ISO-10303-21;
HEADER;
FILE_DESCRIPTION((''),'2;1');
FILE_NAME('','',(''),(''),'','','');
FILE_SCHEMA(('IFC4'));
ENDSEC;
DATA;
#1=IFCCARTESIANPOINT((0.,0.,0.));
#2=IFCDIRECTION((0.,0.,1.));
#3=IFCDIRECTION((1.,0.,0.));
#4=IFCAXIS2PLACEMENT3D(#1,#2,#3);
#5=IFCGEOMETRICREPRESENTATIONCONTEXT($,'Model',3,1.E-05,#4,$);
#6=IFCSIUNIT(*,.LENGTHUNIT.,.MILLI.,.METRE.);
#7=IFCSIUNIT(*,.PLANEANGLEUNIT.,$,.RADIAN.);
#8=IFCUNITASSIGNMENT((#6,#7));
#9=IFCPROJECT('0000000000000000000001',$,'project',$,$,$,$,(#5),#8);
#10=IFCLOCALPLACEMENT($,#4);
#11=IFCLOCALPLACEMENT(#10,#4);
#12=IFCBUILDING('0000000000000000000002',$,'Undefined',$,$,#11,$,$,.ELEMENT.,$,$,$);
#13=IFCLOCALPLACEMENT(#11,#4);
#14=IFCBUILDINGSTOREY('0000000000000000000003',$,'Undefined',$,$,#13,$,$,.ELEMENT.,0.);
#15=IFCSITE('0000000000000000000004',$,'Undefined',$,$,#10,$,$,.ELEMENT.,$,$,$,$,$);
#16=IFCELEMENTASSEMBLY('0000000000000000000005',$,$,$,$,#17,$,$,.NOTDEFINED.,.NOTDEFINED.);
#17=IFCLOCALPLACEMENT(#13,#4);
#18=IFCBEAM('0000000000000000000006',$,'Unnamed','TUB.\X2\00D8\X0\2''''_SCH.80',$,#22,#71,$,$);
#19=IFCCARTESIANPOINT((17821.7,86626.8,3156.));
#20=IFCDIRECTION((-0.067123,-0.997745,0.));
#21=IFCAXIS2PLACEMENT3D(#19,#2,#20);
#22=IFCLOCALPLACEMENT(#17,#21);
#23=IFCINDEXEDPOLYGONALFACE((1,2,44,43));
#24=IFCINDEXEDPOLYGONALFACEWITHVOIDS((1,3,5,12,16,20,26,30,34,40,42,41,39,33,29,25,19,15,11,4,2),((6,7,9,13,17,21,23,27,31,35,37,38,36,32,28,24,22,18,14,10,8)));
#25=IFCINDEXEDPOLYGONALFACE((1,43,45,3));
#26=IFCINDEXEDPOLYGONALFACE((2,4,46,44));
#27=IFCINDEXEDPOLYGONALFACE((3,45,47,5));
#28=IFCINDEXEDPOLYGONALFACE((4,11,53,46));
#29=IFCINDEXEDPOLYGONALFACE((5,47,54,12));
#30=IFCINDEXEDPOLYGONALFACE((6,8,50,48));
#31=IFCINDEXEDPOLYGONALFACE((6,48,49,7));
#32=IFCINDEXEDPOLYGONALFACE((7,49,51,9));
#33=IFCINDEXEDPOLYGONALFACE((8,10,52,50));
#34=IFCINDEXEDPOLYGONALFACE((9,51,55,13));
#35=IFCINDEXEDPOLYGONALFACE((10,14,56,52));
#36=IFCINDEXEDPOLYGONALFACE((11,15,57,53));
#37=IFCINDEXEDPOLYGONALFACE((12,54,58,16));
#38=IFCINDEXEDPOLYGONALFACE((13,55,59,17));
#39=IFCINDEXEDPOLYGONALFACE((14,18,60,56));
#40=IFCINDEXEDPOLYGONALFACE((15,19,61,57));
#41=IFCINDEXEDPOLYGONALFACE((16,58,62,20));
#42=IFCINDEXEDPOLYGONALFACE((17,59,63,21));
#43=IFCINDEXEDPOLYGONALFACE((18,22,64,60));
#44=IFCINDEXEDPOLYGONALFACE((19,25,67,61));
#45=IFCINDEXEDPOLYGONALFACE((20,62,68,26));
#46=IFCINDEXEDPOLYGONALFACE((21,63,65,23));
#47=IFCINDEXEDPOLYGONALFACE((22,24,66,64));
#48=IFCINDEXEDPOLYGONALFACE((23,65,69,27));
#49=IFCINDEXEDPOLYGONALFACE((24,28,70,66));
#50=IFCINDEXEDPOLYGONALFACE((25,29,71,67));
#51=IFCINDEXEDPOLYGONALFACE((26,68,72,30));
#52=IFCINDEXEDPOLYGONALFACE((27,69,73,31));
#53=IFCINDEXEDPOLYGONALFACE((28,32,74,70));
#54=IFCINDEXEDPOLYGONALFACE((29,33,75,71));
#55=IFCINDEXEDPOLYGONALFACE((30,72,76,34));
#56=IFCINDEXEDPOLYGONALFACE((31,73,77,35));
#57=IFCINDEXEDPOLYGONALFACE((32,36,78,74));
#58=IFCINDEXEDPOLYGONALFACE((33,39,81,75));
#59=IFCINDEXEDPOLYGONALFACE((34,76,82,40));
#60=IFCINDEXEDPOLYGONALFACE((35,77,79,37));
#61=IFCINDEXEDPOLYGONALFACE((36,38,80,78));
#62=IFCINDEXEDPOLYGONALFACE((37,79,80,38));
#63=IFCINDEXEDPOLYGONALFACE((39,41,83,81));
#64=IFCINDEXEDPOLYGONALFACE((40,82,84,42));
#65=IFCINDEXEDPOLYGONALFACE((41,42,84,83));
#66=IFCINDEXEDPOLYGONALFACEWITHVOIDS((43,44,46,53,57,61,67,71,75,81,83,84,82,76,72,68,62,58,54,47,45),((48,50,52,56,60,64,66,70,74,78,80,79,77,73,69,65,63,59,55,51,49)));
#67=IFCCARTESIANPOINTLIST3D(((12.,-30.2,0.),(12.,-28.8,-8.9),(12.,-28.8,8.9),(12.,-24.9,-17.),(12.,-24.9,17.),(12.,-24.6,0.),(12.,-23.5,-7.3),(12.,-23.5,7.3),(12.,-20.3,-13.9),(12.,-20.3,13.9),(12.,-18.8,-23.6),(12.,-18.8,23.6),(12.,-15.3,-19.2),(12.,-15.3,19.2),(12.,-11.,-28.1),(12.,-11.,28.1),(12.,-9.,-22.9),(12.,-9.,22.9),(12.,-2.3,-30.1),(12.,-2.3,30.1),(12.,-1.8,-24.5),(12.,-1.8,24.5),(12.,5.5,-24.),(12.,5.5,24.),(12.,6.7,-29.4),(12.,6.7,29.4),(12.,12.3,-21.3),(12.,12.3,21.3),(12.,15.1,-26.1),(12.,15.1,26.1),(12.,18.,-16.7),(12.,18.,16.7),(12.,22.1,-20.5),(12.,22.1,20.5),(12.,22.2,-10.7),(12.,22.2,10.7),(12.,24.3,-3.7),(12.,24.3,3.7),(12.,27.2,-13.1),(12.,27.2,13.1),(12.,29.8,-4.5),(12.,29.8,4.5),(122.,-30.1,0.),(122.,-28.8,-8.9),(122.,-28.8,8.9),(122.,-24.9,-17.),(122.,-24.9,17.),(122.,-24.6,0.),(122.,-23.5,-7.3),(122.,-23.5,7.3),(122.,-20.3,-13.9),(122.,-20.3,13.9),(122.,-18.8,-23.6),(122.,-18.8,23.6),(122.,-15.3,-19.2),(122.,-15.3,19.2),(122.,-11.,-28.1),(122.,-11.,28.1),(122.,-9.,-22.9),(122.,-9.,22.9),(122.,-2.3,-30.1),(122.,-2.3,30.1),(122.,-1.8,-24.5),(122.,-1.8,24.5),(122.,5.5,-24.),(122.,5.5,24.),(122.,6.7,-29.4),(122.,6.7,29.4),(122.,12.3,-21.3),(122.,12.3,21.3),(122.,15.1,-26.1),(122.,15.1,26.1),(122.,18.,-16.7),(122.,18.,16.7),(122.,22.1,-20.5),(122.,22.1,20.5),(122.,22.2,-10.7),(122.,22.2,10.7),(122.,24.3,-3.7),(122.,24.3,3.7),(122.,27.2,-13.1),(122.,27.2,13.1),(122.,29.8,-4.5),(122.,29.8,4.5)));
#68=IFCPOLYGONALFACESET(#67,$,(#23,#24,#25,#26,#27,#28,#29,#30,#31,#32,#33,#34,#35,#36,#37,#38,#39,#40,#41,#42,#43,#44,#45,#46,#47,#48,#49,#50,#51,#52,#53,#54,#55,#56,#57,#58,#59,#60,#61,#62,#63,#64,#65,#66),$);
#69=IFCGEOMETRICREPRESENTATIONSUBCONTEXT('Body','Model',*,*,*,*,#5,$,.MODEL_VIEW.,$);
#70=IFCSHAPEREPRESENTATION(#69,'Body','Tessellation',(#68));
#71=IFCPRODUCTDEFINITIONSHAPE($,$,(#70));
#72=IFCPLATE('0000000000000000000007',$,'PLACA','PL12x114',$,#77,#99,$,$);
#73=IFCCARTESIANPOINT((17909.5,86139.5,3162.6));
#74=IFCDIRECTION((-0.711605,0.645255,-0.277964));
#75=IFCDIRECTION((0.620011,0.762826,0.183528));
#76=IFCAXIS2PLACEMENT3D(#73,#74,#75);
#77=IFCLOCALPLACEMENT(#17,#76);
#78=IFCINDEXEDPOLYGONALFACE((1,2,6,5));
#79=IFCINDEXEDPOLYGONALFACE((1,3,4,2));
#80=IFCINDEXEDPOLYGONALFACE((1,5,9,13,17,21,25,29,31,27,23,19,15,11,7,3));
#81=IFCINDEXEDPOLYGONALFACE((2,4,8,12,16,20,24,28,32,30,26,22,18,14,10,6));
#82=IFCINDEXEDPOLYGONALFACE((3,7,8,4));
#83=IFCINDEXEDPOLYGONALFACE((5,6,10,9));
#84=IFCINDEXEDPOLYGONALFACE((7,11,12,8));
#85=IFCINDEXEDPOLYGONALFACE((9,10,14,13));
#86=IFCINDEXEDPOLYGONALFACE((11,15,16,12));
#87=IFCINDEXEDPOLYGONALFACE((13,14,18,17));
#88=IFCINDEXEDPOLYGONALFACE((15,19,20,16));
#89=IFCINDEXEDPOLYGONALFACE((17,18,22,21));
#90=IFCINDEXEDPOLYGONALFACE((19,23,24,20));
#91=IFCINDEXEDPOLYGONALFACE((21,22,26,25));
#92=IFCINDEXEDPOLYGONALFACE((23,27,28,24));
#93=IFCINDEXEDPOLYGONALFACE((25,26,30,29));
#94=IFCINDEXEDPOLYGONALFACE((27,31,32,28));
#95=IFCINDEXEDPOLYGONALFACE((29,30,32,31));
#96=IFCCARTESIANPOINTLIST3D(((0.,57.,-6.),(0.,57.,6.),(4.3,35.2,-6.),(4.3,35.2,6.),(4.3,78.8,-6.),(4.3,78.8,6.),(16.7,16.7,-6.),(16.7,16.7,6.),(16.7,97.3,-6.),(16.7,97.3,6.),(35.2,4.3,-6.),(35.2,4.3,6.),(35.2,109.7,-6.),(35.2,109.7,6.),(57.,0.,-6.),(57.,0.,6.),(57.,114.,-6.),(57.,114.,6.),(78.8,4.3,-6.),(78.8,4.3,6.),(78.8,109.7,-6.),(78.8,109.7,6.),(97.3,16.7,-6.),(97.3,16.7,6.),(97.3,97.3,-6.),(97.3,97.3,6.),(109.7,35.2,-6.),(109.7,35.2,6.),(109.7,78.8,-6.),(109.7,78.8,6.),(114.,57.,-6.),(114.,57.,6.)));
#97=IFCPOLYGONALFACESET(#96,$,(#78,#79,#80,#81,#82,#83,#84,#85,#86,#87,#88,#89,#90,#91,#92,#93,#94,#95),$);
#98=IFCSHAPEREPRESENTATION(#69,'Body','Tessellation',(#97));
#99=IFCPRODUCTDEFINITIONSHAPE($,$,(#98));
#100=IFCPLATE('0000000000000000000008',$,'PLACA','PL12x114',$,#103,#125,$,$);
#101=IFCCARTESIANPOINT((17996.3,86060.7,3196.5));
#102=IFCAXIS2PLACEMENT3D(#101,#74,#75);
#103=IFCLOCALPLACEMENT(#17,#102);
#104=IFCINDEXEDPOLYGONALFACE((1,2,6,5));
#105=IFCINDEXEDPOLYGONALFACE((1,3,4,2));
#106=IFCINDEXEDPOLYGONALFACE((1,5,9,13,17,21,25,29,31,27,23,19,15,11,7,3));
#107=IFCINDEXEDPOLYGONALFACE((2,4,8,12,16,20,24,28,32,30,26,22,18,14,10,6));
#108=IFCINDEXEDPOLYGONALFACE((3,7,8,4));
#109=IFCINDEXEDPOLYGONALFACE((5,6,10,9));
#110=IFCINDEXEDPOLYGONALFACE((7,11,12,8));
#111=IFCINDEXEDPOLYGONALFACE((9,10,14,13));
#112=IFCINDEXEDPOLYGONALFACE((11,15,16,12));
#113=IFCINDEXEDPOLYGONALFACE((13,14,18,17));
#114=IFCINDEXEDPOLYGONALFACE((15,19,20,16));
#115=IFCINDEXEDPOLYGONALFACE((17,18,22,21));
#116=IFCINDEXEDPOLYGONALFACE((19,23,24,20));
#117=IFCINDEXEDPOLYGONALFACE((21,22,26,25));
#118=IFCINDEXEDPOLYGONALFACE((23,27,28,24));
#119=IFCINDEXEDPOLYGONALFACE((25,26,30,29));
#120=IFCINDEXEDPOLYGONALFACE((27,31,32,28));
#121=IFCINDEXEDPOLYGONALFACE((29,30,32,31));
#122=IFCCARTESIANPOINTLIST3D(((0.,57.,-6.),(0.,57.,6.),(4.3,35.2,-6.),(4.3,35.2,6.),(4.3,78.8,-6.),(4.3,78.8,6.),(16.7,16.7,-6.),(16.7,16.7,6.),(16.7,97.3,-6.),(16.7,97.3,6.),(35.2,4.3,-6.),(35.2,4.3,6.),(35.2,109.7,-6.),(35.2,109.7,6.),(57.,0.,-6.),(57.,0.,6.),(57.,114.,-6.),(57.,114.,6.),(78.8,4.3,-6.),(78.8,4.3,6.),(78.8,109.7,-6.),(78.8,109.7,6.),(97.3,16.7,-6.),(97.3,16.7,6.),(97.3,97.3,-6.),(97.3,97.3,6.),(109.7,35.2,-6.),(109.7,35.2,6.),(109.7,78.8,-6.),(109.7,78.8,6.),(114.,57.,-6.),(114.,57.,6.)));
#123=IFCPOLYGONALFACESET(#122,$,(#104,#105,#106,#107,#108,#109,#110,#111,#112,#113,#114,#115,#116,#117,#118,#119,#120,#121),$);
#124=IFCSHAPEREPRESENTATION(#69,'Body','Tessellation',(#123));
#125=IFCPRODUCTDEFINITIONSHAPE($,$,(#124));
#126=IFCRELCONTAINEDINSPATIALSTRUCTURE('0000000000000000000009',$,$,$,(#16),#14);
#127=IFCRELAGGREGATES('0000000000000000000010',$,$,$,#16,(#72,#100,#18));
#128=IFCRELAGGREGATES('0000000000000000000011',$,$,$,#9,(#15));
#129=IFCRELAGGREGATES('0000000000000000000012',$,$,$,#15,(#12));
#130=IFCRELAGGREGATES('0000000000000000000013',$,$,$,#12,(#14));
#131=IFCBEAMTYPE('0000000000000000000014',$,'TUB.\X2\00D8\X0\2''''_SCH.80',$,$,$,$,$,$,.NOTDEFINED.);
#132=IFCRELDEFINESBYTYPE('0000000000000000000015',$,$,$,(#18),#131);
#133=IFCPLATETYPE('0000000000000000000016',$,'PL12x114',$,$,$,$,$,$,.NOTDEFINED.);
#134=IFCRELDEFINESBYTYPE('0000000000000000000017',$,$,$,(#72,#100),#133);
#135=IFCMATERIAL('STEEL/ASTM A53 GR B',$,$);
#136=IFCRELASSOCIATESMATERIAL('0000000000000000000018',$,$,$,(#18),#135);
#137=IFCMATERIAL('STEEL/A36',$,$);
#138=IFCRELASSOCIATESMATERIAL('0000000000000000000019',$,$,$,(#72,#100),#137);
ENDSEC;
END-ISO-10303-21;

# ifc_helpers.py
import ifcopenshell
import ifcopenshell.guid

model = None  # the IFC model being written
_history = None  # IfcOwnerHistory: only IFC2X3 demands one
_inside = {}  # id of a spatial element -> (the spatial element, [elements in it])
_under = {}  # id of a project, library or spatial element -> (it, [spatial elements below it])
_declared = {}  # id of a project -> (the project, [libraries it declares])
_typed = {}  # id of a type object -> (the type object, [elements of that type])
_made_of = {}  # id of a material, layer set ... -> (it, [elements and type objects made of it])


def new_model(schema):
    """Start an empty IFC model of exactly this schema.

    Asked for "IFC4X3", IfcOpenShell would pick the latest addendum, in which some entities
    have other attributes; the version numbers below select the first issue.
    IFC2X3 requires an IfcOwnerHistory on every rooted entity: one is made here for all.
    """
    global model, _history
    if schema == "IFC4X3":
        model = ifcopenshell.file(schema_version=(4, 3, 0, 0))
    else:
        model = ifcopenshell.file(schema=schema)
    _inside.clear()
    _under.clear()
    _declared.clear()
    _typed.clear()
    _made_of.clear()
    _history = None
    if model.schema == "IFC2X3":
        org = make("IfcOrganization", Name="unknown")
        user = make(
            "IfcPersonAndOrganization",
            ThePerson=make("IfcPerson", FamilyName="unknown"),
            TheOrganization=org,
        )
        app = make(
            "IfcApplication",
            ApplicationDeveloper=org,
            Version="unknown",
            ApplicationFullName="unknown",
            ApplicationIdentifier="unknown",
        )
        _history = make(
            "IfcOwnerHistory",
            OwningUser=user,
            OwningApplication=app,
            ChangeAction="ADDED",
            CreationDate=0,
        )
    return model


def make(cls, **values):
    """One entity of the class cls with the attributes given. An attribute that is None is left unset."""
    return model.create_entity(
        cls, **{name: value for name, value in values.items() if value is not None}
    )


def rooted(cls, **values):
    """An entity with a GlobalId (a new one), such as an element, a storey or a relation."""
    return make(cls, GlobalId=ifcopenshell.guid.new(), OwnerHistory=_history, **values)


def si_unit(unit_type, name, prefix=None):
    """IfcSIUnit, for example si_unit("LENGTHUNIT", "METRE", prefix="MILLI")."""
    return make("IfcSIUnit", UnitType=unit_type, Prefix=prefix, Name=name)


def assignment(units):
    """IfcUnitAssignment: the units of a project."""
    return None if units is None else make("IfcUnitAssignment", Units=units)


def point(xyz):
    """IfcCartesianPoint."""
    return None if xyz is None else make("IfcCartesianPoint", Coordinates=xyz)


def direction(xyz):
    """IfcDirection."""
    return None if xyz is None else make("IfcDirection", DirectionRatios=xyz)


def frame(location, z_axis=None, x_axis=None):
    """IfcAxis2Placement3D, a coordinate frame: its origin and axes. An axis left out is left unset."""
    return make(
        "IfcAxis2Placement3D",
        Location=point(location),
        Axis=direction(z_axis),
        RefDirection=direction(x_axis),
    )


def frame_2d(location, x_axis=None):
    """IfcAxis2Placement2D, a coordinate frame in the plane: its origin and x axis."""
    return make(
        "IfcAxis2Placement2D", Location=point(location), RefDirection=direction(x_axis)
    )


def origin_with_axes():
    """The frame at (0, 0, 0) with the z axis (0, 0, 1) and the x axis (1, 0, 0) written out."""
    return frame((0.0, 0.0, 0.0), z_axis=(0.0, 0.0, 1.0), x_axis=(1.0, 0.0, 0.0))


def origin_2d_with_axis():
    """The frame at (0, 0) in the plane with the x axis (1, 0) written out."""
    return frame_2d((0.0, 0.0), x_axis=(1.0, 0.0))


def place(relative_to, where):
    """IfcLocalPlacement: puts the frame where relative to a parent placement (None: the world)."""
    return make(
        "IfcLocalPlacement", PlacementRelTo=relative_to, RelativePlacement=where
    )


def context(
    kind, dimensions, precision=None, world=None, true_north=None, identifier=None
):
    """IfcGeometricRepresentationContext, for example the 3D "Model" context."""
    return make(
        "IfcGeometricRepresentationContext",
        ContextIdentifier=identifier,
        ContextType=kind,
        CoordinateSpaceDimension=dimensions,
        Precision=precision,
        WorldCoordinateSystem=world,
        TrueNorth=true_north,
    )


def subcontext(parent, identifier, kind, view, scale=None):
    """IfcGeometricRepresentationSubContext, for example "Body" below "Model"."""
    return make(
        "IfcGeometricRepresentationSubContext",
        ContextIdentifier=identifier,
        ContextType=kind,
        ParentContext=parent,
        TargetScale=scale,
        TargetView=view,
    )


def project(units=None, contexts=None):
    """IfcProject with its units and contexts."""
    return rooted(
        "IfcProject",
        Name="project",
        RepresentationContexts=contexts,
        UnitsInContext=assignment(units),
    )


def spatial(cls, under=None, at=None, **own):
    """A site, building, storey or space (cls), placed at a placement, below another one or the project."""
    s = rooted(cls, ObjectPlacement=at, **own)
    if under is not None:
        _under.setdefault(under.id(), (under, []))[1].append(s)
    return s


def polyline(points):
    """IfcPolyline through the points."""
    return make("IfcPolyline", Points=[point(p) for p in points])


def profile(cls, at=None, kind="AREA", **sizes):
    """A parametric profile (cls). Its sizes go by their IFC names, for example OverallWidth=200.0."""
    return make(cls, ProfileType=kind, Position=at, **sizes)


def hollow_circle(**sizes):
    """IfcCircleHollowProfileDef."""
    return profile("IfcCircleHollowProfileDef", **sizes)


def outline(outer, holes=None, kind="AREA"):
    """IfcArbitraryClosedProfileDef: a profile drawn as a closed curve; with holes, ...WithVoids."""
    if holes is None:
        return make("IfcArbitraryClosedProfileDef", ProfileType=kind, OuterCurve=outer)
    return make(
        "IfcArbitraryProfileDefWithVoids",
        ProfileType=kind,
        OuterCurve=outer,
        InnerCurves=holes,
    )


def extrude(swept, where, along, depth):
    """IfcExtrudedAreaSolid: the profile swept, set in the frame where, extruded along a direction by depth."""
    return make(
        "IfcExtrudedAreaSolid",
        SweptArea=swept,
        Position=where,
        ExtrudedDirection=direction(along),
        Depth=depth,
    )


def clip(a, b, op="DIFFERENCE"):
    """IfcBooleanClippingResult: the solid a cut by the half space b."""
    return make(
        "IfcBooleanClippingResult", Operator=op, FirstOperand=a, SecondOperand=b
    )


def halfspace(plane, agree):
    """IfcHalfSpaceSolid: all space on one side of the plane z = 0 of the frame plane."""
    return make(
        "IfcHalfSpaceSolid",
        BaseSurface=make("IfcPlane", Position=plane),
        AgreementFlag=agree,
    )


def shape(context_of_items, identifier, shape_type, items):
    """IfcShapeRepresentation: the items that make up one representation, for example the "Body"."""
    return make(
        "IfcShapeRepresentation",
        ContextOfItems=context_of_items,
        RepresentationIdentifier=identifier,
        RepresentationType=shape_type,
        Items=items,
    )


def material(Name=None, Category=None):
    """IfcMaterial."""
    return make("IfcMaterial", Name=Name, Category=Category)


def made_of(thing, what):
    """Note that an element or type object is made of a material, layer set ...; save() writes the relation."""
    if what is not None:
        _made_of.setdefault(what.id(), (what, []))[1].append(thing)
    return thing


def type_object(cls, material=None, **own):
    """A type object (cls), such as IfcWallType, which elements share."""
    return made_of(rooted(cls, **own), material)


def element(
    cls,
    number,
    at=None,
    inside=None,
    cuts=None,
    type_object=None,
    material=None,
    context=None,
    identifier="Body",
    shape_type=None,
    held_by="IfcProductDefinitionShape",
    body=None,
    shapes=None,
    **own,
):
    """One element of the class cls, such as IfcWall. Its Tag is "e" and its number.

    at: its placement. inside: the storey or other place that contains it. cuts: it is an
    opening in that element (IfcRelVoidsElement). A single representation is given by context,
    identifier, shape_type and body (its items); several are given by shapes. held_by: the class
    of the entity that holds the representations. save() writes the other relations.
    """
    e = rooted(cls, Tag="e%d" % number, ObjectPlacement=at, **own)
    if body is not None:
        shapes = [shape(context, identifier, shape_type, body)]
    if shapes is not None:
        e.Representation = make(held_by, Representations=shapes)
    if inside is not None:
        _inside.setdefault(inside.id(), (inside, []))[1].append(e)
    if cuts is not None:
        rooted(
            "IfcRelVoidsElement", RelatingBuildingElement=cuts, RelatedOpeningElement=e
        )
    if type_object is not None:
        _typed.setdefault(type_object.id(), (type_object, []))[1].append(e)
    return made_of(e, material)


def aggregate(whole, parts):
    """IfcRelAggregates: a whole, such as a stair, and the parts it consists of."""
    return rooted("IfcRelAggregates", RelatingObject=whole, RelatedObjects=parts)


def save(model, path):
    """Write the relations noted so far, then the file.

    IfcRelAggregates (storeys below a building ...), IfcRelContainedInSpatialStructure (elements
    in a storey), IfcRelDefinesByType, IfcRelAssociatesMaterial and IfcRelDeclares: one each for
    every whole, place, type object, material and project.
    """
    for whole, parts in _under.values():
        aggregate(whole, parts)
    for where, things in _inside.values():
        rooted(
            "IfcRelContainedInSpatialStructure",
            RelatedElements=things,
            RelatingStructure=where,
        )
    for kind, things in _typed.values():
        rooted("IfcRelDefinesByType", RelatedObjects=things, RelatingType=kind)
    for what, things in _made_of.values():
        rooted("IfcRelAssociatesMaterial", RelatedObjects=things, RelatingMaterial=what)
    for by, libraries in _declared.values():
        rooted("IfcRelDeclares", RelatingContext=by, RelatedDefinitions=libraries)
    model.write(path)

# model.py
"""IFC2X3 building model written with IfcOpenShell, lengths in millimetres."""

from ifc_helpers import new_model, si_unit, frame, origin_with_axes, origin_2d_with_axis, place, context, subcontext, project, spatial, polyline, hollow_circle, outline, extrude, clip, halfspace, material, type_object, element, aggregate, save


model = new_model("IFC2X3")

# Units and contexts
model_context = context("Model", 3, precision=1e-05, world=origin_with_axes())
body_context = subcontext(model_context, "Body", "Model", "MODEL_VIEW")
ifc_project = project(units=[si_unit("LENGTHUNIT", "METRE", prefix="MILLI"), si_unit("PLANEANGLEUNIT", "RADIAN")], contexts=[model_context])

# Site, building, storey
site_placement = place(None, origin_with_axes())
site = spatial("IfcSite", under=ifc_project, at=site_placement, Name="Undefined", CompositionType="ELEMENT")
building_placement = place(site_placement, origin_with_axes())
building = spatial("IfcBuilding", under=site, at=building_placement, Name="Undefined", CompositionType="ELEMENT")
storey_placement = place(building_placement, origin_with_axes())
storey = spatial("IfcBuildingStorey", under=building, at=storey_placement, Name="Undefined", CompositionType="ELEMENT", Elevation=0.0)

# Element assembly, beam, plates
assembly_placement = place(storey_placement, origin_with_axes())
assembly = element("IfcElementAssembly", 1, at=assembly_placement, inside=storey, AssemblyPlace="NOTDEFINED", PredefinedType="NOTDEFINED")
ifc_material_1 = material(Name="STEEL/ASTM A53 GR B")
beam_type_1 = type_object("IfcBeamType", Name="TUB.Ø2''_SCH.80", PredefinedType="NOTDEFINED")
beam_1_placement = place(assembly_placement, frame((17821.7, 86626.8, 3156.0), z_axis=(0.0, 0.0, 1.0), x_axis=(-0.067123, -0.997745, 0.0)))
beam_1 = element("IfcBeam", 2, at=beam_1_placement, type_object=beam_type_1, material=ifc_material_1, Name="Unnamed", Description="TUB.Ø2''_SCH.80", context=body_context, shape_type="Clipping", body=[
    clip(extrude(hollow_circle(Radius=30.1, WallThickness=5.5, at=origin_2d_with_axis()), frame((122.0, 0.0, 0.0), z_axis=(-1.0, 0.0, 0.0), x_axis=(0.0, -1.0, 0.0)), (0.0, 0.0, 1.0), 122.0), halfspace(frame((12.0, 0.0, 0.0), z_axis=(1.0, 0.0, 0.0), x_axis=(0.0, -1.0, 0.0)), True)),
])
ifc_material_2 = material(Name="STEEL/A36")
plate_type_1 = type_object("IfcPlateType", Name="PL12x114", PredefinedType="NOTDEFINED")
plate_1_placement = place(assembly_placement, frame((17909.5, 86139.5, 3162.6), z_axis=(-0.711605, 0.645255, -0.277964), x_axis=(0.620011, 0.762826, 0.183528)))
plate_1 = element("IfcPlate", 3, at=plate_1_placement, type_object=plate_type_1, material=ifc_material_2, Name="PLACA", Description="PL12x114", context=body_context, shape_type="SweptSolid", body=[
    extrude(outline(polyline([(0.0, 57.0), (4.3, 35.2), (16.7, 16.7), (35.2, 4.3), (57.0, 0.0), (57.0, 0.0), (78.8, 4.3), (97.3, 16.7), (109.7, 35.2), (114.0, 57.0), (114.0, 57.0), (109.7, 78.8), (97.3, 97.3), (78.8, 109.7), (57.0, 114.0), (57.0, 114.0), (35.2, 109.7), (16.7, 97.3), (4.3, 78.8), (0.0, 57.0), (0.0, 57.0)])), frame((0.0, 0.0, -6.0), z_axis=(0.0, 0.0, 1.0), x_axis=(1.0, 0.0, 0.0)), (0.0, 0.0, 1.0), 12.0),
])
plate_2_placement = place(assembly_placement, frame((17996.3, 86060.7, 3196.5), z_axis=(-0.711605, 0.645255, -0.277964), x_axis=(0.620011, 0.762826, 0.183528)))
plate_2 = element("IfcPlate", 4, at=plate_2_placement, type_object=plate_type_1, material=ifc_material_2, Name="PLACA", Description="PL12x114", context=body_context, shape_type="SweptSolid", body=[
    extrude(outline(polyline([(0.0, 57.0), (4.3, 35.2), (16.7, 16.7), (35.2, 4.3), (57.0, 0.0), (57.0, 0.0), (78.8, 4.3), (97.3, 16.7), (109.7, 35.2), (114.0, 57.0), (114.0, 57.0), (109.7, 78.8), (97.3, 97.3), (78.8, 109.7), (57.0, 114.0), (57.0, 114.0), (35.2, 109.7), (16.7, 97.3), (4.3, 78.8), (0.0, 57.0), (0.0, 57.0)])), frame((0.0, 0.0, -6.0), z_axis=(0.0, 0.0, 1.0), x_axis=(1.0, 0.0, 0.0)), (0.0, 0.0, 1.0), 12.0),
])
aggregate(assembly, [plate_1, plate_2, beam_1])

save(model, "model.ifc")
